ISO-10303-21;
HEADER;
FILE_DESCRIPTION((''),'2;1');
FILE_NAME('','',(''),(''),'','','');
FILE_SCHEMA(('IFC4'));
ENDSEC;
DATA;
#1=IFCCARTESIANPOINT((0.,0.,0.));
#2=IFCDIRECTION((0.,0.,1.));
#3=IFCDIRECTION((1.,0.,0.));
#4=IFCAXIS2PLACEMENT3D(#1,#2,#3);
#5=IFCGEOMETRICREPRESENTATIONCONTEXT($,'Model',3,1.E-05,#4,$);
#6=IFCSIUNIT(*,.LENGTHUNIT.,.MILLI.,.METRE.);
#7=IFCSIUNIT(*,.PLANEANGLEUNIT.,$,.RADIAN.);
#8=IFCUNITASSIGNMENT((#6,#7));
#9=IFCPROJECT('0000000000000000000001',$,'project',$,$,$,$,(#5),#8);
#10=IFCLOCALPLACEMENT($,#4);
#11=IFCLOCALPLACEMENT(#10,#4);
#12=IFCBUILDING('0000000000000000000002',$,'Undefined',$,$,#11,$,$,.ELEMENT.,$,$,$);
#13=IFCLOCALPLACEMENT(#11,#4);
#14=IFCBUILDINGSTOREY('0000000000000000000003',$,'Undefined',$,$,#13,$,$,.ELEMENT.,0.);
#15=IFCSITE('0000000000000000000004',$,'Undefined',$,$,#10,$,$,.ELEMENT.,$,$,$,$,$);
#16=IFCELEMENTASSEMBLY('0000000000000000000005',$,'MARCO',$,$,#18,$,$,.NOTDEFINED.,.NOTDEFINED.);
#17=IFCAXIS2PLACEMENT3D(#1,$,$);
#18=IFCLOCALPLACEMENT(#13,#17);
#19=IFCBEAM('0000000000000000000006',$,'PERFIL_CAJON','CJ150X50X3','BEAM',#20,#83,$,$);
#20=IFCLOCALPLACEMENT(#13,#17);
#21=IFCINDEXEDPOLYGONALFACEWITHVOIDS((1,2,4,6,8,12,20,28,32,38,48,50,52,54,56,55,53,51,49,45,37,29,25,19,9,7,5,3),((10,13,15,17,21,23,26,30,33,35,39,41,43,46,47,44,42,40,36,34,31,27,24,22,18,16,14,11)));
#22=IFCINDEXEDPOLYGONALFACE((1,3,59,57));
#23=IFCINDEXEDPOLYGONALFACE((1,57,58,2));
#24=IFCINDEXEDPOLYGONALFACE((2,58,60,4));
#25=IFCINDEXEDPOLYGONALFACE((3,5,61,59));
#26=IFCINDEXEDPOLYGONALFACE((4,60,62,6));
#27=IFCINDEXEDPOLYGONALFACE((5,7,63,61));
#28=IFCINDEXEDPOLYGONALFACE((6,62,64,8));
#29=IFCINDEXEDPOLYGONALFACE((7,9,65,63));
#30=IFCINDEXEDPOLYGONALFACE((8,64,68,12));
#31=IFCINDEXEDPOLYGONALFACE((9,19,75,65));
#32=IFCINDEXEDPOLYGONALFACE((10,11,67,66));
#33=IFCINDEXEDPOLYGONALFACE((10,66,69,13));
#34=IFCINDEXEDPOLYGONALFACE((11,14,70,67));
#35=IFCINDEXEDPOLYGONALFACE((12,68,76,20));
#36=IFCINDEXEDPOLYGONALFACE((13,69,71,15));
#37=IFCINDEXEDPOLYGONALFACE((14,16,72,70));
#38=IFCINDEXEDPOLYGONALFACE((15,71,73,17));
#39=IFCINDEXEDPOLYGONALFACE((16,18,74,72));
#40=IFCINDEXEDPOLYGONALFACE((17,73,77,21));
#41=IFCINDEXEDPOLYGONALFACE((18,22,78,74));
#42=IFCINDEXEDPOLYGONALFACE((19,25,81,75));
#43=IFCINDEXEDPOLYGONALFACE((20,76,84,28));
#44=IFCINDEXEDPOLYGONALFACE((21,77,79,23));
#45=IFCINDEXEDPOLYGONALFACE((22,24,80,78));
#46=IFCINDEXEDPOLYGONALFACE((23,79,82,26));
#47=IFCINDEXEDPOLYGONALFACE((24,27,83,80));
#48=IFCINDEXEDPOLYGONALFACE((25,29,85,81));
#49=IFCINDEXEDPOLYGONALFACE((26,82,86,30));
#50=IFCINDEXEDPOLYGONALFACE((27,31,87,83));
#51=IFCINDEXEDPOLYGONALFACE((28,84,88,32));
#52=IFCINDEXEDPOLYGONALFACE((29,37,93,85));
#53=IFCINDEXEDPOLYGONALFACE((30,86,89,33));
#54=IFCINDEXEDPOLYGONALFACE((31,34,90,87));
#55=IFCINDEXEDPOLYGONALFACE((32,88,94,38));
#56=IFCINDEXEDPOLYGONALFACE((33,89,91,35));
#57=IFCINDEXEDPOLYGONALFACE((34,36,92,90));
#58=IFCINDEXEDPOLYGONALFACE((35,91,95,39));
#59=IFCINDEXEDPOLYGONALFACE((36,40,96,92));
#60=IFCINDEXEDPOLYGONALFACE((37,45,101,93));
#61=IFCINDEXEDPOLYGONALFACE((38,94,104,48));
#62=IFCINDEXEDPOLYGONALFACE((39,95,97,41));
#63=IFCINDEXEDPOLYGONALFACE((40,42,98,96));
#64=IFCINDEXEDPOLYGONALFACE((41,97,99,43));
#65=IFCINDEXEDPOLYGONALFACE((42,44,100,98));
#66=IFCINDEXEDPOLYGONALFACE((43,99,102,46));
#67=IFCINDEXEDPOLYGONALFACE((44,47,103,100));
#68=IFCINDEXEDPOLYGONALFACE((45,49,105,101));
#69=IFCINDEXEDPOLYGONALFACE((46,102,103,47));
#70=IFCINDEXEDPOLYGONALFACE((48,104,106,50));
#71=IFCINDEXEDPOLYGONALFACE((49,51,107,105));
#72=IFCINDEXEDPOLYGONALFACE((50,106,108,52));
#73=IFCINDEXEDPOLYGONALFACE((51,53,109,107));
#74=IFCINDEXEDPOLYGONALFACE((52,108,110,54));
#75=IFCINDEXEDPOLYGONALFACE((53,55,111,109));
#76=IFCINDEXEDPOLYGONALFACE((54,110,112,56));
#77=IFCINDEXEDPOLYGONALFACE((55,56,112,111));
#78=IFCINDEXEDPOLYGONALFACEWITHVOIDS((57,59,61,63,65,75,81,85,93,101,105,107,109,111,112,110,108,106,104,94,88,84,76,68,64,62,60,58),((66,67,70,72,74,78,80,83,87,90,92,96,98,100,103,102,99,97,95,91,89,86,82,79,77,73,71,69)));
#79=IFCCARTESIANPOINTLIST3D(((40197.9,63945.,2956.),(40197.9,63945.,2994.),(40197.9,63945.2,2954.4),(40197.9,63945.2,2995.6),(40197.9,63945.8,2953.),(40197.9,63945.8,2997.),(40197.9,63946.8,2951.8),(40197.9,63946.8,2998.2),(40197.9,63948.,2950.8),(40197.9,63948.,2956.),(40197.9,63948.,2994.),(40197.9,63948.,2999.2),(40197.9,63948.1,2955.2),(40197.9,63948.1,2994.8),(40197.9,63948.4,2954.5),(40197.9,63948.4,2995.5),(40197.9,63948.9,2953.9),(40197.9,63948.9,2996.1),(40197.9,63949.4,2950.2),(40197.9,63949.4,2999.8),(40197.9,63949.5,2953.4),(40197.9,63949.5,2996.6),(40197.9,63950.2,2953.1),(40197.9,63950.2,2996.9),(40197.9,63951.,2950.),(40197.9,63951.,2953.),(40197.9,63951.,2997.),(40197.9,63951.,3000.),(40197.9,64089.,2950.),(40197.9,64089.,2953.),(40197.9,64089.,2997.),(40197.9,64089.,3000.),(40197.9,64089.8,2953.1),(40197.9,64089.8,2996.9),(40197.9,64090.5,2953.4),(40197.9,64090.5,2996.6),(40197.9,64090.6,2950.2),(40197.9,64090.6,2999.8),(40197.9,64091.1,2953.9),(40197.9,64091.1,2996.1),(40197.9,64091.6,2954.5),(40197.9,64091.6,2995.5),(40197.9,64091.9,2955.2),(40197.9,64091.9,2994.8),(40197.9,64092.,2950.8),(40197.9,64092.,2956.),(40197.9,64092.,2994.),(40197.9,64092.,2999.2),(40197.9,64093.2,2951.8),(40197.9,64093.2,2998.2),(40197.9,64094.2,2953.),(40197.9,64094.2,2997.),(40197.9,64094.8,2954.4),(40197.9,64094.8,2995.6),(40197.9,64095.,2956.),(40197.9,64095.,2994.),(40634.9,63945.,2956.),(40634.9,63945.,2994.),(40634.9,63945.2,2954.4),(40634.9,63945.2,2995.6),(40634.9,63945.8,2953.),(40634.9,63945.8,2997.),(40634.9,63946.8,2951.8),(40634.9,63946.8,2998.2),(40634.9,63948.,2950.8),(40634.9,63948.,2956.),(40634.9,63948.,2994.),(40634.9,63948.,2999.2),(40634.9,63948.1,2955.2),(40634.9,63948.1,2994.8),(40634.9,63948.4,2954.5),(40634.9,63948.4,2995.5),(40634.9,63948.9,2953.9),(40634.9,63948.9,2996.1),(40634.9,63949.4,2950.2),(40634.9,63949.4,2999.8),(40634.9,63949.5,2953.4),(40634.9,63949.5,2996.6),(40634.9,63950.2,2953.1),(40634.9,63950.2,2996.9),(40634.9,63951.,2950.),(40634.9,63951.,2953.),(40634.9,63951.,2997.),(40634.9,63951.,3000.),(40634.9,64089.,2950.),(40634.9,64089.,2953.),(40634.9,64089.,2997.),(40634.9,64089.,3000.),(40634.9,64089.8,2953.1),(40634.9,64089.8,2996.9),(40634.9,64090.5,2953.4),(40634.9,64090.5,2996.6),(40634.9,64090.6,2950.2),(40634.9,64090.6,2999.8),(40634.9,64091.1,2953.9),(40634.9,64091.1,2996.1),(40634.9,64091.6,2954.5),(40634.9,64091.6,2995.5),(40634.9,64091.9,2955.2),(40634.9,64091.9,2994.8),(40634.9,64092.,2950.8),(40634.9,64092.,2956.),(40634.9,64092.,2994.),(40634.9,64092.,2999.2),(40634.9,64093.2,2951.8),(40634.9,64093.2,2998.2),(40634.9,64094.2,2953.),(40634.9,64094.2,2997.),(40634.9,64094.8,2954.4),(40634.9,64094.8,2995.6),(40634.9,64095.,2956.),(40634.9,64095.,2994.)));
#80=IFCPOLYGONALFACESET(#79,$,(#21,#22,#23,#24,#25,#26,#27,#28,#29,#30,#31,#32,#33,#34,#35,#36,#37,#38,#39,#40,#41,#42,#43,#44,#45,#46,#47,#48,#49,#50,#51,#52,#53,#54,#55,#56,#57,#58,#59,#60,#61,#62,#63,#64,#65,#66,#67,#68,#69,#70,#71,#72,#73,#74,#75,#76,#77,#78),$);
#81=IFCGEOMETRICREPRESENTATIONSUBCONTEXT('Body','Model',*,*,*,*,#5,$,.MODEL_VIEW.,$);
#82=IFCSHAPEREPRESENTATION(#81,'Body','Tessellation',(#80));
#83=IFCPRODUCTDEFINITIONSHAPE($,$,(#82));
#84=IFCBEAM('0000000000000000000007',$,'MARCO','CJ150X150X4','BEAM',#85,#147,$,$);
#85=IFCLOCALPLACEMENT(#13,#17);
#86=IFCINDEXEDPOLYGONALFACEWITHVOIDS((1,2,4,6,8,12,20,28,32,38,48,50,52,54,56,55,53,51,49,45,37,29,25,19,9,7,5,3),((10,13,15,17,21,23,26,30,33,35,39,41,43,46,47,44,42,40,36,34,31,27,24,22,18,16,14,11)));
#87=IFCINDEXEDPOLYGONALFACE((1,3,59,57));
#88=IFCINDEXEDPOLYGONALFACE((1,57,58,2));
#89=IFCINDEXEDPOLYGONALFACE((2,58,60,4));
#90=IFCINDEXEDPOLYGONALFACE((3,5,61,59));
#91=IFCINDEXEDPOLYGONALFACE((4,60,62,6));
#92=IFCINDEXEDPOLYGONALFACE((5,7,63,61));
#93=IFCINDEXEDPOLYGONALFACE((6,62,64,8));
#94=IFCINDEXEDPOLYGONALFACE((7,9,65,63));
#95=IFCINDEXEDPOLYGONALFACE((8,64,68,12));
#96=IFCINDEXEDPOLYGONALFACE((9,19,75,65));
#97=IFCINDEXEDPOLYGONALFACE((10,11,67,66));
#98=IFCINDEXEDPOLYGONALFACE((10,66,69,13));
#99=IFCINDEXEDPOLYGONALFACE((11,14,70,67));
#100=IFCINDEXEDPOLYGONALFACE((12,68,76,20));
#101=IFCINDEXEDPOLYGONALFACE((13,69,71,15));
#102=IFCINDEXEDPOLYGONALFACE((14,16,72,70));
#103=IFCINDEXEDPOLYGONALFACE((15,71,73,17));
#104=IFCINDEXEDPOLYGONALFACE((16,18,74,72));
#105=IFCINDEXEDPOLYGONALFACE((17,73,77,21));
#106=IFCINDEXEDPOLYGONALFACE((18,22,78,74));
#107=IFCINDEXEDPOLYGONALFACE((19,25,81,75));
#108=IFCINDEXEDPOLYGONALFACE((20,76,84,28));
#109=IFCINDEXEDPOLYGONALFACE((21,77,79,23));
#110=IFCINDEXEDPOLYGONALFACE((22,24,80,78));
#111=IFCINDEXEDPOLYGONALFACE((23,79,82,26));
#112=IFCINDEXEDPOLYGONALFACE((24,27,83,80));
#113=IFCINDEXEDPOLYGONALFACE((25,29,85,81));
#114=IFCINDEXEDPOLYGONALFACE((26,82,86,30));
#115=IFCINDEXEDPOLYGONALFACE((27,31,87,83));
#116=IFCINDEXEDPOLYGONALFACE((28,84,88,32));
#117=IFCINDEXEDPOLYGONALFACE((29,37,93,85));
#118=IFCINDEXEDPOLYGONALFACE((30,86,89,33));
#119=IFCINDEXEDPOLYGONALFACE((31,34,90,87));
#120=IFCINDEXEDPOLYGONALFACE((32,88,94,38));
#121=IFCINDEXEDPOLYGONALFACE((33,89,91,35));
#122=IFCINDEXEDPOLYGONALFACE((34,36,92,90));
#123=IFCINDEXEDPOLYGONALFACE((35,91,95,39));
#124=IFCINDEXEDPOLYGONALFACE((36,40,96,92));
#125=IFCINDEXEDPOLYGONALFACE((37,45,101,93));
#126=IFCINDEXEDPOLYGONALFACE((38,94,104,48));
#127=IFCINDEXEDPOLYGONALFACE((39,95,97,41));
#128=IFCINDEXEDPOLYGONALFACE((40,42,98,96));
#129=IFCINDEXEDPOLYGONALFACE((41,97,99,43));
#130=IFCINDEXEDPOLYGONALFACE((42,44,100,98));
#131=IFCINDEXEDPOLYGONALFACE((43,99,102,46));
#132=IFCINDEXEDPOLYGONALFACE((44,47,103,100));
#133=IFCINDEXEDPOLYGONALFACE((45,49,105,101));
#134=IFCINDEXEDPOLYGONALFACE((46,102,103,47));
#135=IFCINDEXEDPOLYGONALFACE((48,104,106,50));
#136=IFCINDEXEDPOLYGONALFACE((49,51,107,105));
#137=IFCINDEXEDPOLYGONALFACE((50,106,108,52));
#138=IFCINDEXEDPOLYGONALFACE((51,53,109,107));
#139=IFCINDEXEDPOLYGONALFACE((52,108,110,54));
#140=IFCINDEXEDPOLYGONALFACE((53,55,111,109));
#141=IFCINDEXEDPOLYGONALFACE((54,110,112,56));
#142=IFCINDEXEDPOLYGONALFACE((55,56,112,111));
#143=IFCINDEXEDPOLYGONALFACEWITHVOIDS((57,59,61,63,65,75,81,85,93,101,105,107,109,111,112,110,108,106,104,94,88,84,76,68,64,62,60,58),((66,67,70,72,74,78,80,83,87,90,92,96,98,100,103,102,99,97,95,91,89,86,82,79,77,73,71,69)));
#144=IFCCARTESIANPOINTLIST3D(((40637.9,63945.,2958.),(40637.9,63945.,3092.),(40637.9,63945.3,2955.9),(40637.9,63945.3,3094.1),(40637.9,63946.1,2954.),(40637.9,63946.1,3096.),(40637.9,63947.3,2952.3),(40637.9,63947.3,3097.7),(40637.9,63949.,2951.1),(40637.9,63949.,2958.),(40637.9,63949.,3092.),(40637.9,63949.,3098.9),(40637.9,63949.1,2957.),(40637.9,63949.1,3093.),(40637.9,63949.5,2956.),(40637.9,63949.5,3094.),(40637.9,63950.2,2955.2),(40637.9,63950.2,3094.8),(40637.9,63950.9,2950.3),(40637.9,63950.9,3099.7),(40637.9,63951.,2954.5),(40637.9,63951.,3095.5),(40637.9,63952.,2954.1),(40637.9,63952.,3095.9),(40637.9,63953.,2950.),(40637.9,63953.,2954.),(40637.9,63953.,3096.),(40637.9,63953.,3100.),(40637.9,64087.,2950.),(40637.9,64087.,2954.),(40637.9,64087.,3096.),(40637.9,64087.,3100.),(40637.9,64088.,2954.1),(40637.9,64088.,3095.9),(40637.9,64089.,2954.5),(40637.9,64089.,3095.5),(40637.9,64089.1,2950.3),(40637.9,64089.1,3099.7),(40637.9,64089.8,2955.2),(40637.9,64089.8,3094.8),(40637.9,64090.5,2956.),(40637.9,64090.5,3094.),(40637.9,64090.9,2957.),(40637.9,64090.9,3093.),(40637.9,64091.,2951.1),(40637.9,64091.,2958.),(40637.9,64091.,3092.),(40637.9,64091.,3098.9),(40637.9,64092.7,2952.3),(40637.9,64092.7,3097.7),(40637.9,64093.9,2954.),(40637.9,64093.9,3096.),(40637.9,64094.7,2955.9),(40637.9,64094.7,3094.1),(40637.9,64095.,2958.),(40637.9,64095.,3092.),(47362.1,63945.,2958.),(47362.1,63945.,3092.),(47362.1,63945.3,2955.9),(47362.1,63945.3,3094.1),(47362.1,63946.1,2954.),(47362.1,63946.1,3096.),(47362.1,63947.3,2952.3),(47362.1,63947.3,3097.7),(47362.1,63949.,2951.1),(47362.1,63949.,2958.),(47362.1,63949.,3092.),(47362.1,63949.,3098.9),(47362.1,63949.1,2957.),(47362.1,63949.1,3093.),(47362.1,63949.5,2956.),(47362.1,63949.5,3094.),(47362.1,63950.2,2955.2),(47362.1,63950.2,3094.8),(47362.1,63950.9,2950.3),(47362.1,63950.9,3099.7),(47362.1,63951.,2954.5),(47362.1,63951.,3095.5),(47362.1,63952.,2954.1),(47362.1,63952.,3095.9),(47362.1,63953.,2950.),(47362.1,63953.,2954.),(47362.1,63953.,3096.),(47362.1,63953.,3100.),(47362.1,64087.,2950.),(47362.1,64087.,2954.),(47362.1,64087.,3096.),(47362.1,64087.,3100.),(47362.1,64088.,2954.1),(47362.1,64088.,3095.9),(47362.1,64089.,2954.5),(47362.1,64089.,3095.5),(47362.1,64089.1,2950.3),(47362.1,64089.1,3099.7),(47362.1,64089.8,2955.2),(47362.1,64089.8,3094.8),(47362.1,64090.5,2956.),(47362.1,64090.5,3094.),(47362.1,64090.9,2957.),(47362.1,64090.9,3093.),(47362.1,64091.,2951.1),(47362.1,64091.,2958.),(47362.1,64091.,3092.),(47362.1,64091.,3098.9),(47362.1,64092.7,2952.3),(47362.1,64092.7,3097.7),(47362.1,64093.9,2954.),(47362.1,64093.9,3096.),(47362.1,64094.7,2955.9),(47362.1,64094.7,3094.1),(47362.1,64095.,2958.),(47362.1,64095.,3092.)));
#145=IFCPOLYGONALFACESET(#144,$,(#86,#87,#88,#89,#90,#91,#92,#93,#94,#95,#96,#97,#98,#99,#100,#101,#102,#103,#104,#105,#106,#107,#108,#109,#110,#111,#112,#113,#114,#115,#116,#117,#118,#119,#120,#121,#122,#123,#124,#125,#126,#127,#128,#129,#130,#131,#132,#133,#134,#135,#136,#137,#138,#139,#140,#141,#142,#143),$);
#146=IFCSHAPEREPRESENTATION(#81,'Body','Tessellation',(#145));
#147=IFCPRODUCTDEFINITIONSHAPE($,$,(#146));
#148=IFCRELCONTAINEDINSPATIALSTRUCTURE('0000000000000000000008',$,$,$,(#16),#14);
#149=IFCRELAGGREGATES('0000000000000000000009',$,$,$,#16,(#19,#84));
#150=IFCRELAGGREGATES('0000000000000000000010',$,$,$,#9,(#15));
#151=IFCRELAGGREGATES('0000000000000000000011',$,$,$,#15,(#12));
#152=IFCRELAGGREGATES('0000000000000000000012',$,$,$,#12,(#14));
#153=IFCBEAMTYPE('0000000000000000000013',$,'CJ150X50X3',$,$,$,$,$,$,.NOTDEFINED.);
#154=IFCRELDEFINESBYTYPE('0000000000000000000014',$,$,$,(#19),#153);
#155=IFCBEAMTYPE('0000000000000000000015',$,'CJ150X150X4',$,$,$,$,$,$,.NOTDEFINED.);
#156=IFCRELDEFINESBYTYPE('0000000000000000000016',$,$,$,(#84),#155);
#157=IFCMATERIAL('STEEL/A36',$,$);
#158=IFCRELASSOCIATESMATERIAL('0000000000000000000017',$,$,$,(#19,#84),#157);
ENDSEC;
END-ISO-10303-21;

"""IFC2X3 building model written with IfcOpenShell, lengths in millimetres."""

from ifc_helpers import new_model, si_unit, frame, origin_with_axes, origin_2d_with_axis, place, context, subcontext, project, spatial, hollow_rectangle, extrude, material, type_object, element, aggregate, save


model = new_model("IFC2X3")

# Units and contexts
model_context = context("Model", 3, precision=1e-05, world=origin_with_axes())
body_context = subcontext(model_context, "Body", "Model", "MODEL_VIEW")
ifc_project = project(units=[si_unit("LENGTHUNIT", "METRE", prefix="MILLI"), si_unit("PLANEANGLEUNIT", "RADIAN")], contexts=[model_context])

# Site, building, storey
site_placement = place(None, origin_with_axes())
site = spatial("IfcSite", under=ifc_project, at=site_placement, Name="Undefined", CompositionType="ELEMENT")
building_placement = place(site_placement, origin_with_axes())
building = spatial("IfcBuilding", under=site, at=building_placement, Name="Undefined", CompositionType="ELEMENT")
storey_placement = place(building_placement, origin_with_axes())
storey = spatial("IfcBuildingStorey", under=building, at=storey_placement, Name="Undefined", CompositionType="ELEMENT", Elevation=0.0)

# Element assembly, beams
assembly_1_placement = place(storey_placement, origin_with_axes())
assembly_1 = element("IfcElementAssembly", 1, at=assembly_1_placement, inside=storey, Name="MARCO", AssemblyPlace="NOTDEFINED", PredefinedType="NOTDEFINED")
ifc_material_1 = material(Name="STEEL/A36")
beam_type_1 = type_object("IfcBeamType", Name="CJ150X50X3", PredefinedType="NOTDEFINED")
beam_1_placement = place(assembly_1_placement, frame((40197.9, 64020.0, 2975.0), z_axis=(0.0, 1.0, 0.0), x_axis=(1.0, 0.0, 0.0)))
beam_1 = element("IfcBeam", 2, at=beam_1_placement, type_object=beam_type_1, material=ifc_material_1, Name="PERFIL_CAJON", Description="CJ150X50X3", ObjectType="BEAM", context=body_context, shape_type="SweptSolid", body=[
    extrude(hollow_rectangle(XDim=50.0, YDim=150.0, WallThickness=3.0, InnerFilletRadius=3.0, OuterFilletRadius=6.0, at=origin_2d_with_axis()), frame((437.0, 0.0, 0.0), z_axis=(-1.0, 0.0, 0.0), x_axis=(0.0, -1.0, 0.0)), (0.0, 0.0, 1.0), 437.0),
])
beam_type_2 = type_object("IfcBeamType", Name="CJ150X150X4", PredefinedType="NOTDEFINED")
beam_2_placement = place(assembly_1_placement, frame((40637.9, 64020.0, 3025.0), z_axis=(0.0, 0.0, 1.0), x_axis=(1.0, 0.0, 0.0)))
beam_2 = element("IfcBeam", 3, at=beam_2_placement, type_object=beam_type_2, material=ifc_material_1, Name="MARCO", Description="CJ150X150X4", ObjectType="BEAM", context=body_context, shape_type="SweptSolid", body=[
    extrude(hollow_rectangle(XDim=150.0, YDim=150.0, WallThickness=4.0, InnerFilletRadius=4.0, OuterFilletRadius=8.0, at=origin_2d_with_axis()), frame((6724.2, 0.0, 0.0), z_axis=(-1.0, 0.0, 0.0), x_axis=(0.0, -1.0, 0.0)), (0.0, 0.0, 1.0), 6724.2),
])

aggregate(assembly_1, [beam_1, beam_2])

save(model, "model.ifc")
